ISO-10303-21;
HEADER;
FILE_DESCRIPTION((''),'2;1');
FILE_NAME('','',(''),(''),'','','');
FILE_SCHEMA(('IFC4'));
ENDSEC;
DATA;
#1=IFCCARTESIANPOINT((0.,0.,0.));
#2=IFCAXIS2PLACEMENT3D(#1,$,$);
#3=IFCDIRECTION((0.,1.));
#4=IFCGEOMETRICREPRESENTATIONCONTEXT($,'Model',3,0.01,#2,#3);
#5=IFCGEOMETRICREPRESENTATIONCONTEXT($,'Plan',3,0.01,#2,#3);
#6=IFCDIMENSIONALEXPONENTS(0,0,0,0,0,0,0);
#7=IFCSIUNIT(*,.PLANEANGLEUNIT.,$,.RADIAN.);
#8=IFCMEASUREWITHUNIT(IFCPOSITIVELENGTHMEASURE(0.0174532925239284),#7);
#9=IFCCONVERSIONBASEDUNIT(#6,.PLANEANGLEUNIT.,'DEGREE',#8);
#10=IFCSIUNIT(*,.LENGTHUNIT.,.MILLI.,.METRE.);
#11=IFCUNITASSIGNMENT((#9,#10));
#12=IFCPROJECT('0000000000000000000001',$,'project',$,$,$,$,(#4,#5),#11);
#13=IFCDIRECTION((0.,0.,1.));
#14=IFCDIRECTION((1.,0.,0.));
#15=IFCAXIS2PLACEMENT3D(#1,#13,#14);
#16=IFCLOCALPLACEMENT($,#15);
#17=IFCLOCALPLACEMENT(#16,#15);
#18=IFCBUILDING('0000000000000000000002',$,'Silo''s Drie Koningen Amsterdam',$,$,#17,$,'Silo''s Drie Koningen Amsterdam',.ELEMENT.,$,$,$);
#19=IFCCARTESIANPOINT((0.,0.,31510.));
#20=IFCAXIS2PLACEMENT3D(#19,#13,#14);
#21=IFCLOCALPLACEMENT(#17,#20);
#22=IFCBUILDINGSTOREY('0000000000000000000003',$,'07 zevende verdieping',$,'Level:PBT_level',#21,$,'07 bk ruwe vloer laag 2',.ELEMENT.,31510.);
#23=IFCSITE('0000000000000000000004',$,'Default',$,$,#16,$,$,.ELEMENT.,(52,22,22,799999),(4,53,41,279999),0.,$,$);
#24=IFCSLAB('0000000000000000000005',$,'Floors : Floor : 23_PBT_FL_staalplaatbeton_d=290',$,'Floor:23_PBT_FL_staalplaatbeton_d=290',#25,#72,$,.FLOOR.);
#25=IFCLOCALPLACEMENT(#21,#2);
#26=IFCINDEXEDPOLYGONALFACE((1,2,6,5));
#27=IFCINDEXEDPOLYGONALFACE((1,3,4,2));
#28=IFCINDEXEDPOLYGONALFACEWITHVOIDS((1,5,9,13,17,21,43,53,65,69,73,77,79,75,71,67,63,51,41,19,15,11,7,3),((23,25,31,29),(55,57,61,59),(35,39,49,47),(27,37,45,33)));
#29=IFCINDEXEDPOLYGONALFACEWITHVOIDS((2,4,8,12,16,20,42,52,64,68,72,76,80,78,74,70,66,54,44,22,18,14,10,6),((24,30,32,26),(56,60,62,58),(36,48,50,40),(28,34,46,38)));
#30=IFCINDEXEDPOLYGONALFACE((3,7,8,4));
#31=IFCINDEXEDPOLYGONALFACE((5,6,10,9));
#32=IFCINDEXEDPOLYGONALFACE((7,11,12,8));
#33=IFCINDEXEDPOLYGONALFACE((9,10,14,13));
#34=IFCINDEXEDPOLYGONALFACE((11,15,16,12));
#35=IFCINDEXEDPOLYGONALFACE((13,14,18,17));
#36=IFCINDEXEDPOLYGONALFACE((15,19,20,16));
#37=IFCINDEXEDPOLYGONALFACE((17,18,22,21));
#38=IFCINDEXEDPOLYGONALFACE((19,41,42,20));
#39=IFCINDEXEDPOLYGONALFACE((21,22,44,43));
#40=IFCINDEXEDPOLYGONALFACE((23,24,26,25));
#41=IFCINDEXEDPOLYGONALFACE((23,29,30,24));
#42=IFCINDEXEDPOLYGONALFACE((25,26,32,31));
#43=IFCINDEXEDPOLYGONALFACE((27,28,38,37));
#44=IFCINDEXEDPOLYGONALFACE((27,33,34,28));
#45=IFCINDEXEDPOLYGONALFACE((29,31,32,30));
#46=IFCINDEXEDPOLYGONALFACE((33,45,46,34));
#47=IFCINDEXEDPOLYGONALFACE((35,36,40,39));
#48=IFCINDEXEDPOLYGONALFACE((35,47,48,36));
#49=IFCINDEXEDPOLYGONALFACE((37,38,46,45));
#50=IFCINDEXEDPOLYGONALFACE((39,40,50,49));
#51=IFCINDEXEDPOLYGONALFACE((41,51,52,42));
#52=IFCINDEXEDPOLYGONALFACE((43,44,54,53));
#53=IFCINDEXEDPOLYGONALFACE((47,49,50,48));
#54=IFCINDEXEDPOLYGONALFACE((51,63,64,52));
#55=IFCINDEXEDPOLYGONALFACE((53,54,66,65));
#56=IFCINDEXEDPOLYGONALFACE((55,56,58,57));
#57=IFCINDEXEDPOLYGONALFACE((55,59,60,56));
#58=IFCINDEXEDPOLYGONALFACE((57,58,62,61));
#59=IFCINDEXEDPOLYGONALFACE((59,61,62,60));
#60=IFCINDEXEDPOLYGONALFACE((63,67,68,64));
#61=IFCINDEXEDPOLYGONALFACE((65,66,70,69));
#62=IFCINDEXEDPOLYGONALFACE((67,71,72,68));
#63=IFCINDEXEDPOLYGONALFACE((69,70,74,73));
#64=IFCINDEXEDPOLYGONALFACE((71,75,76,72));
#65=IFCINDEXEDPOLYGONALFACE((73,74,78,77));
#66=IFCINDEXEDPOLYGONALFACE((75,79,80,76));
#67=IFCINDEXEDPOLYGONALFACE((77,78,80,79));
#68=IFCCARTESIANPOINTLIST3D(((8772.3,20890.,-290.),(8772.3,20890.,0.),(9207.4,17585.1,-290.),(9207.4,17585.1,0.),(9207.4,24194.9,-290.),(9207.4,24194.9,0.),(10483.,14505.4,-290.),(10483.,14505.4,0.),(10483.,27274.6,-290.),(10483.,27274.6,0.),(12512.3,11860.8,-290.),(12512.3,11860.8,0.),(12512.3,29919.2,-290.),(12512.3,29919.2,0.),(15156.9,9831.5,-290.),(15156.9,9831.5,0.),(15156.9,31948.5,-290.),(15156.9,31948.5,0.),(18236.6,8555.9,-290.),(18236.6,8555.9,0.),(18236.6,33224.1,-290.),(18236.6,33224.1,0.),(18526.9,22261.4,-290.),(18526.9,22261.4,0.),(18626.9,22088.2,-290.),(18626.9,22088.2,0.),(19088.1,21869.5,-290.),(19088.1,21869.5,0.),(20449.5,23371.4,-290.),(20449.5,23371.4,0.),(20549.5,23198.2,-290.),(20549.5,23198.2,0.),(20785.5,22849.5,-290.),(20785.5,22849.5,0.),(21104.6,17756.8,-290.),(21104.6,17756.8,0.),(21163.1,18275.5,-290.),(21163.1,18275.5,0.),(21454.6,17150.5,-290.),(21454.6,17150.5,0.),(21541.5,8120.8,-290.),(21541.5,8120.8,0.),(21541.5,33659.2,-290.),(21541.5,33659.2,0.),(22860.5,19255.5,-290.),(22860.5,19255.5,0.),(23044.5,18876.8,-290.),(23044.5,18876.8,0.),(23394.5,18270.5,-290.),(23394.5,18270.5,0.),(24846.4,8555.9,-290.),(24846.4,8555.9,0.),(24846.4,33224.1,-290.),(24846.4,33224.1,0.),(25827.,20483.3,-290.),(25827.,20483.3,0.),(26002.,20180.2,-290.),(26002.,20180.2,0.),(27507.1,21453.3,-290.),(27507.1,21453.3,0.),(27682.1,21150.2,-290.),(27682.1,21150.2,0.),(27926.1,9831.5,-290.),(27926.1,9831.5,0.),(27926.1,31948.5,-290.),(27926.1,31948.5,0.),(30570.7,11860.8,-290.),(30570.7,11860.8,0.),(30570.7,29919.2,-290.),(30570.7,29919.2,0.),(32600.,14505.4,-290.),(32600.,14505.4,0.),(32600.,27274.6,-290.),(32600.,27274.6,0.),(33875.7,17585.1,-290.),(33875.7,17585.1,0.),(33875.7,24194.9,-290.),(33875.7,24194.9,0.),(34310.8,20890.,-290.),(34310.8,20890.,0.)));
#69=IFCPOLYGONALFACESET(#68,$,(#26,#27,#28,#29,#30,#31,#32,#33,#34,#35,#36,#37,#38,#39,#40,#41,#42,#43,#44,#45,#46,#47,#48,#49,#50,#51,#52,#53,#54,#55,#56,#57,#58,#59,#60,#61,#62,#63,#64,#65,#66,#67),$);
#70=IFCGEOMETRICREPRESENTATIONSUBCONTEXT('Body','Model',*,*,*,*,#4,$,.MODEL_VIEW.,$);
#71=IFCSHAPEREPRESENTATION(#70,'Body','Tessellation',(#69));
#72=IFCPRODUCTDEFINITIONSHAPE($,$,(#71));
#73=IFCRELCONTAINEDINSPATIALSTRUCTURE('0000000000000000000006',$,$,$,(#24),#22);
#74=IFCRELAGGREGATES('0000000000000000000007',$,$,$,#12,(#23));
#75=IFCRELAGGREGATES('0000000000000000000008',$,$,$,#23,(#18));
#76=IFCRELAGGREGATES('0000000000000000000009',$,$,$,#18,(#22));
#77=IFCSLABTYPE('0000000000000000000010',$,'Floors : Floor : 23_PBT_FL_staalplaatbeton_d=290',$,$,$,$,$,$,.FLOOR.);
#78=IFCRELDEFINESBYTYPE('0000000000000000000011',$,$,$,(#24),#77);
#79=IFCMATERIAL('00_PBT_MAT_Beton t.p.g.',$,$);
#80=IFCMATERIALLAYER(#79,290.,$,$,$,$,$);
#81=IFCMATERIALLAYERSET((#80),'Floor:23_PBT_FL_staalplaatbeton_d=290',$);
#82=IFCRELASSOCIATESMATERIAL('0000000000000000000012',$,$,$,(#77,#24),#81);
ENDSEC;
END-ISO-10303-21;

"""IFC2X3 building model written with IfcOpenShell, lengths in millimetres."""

from ifc_helpers import new_model, entity, si_unit, converted_unit, direction, frame, frame_2d, origin, origin_with_axes, place, context, subcontext, project, spatial, polyline, rectangle, outline, extrude, material, layer, layer_set, layer_usage, type_object, element, save


model = new_model("IFC2X3")

# Units and contexts
model_context = context("Model", 3, precision=0.01, world=origin(), true_north=direction((0.0, 1.0)))
plan_context = context("Plan", 3, precision=0.01, world=origin(), true_north=direction((0.0, 1.0)))
body_context = subcontext(model_context, "Body", "Model", "MODEL_VIEW")
ifc_project = project(units=[converted_unit("PLANEANGLEUNIT", "DEGREE", entity("IfcPositiveLengthMeasure", 0.0174532925239284), si_unit("PLANEANGLEUNIT", "RADIAN"), dimensions=[0, 0, 0, 0, 0, 0, 0]), si_unit("LENGTHUNIT", "METRE", prefix="MILLI")], contexts=[model_context, plan_context])

# Site, building, storey
site_placement = place(None, origin_with_axes())
site = spatial("IfcSite", under=ifc_project, at=site_placement, Name="Default", CompositionType="ELEMENT", RefLatitude=(52, 22, 22, 799999), RefLongitude=(4, 53, 41, 279999), RefElevation=0.0)
building_placement = place(site_placement, origin_with_axes())
building = spatial("IfcBuilding", under=site, at=building_placement, Name="Silo's Drie Koningen Amsterdam", LongName="Silo's Drie Koningen Amsterdam", CompositionType="ELEMENT")
storey_placement = place(building_placement, frame((0.0, 0.0, 31510.0), z_axis=(0.0, 0.0, 1.0), x_axis=(1.0, 0.0, 0.0)))
storey = spatial("IfcBuildingStorey", under=building, at=storey_placement, Name="07 zevende verdieping", ObjectType="Level:PBT_level", LongName="07 bk ruwe vloer laag 2", CompositionType="ELEMENT", Elevation=31510.0)

# Slab, openings
ifc_material = material(Name="00_PBT_MAT_Beton t.p.g.")
ifc_layer = layer(ifc_material, 290.0)
ifc_layer_set = layer_set([ifc_layer], Name="Floor:23_PBT_FL_staalplaatbeton_d=290")
ifc_layer_usage = layer_usage(ifc_layer_set, "AXIS3", "POSITIVE", 0.0)
slab_type = type_object("IfcSlabType", Name="Floors : Floor : 23_PBT_FL_staalplaatbeton_d=290", PredefinedType="FLOOR", material=ifc_layer_set)
slab_placement = place(storey_placement, frame((8772.3, 8120.8, -290.0), z_axis=(0.0, 0.0, 1.0), x_axis=(1.0, 0.0, 0.0)))
slab = element("IfcSlab", 1, at=slab_placement, inside=storey, type_object=slab_type, material=ifc_layer_usage, Name="Floors : Floor : 23_PBT_FL_staalplaatbeton_d=290", ObjectType="Floor:23_PBT_FL_staalplaatbeton_d=290", PredefinedType="FLOOR", context=body_context, shape_type="SweptSolid", body=[
    extrude(outline(polyline([(9029.2, -9029.2), (11058.5, -6384.6), (12334.1, -3304.9), (12769.2, 0.0), (12334.1, 3304.9), (11058.5, 6384.6), (9029.2, 9029.2), (6384.6, 11058.5), (3304.9, 12334.1), (0.0, 12769.2), (-3304.9, 12334.1), (-6384.6, 11058.5), (-9029.2, 9029.2), (-11058.5, 6384.6), (-12334.1, 3304.9), (-12769.2, 0.0), (-12334.1, -3304.9), (-11058.5, -6384.6), (-9029.2, -9029.2), (-6384.6, -11058.5), (-3304.9, -12334.1), (0.0, -12769.2), (3304.9, -12334.1), (6384.6, -11058.5), (9029.2, -9029.2)])), frame((12769.2, 12769.2, 290.0), z_axis=(0.0, 0.0, -1.0), x_axis=(-1.0, 0.0, 0.0)), (0.0, 0.0, 1.0), 290.0),
])
opening_1_placement = place(slab_placement, origin_with_axes())
element("IfcOpeningElement", 2, at=opening_1_placement, cuts=slab, ObjectType="Opening", context=body_context, shape_type="SweptSolid", body=[
    extrude(outline(polyline([(-980.0, -2075.0), (980.0, -2075.0), (980.0, 2075.0), (-980.0, 2075.0), (-980.0, -2075.0)])), frame((12202.0, 12441.7, 0.0), z_axis=(0.0, 0.0, 1.0), x_axis=(-0.866025, -0.5, 0.0)), (0.0, 0.0, 1.0), 290.0),
])
opening_2_placement = place(slab_placement, origin_with_axes())
element("IfcOpeningElement", 3, at=opening_2_placement, cuts=slab, ObjectType="Opening", context=body_context, shape_type="SweptSolid", body=[
    extrude(rectangle(XDim=700.0, YDim=2240.0, at=frame_2d((0.0, 0.0), x_axis=(1.0, 0.0))), frame((13477.3, 9892.9, 0.0), z_axis=(0.0, 0.0, 1.0), x_axis=(0.5, -0.866025, 0.0)), (0.0, 0.0, 1.0), 290.0),
])
opening_3_placement = place(slab_placement, origin_with_axes())
element("IfcOpeningElement", 4, at=opening_3_placement, cuts=slab, ObjectType="Opening", context=body_context, shape_type="SweptSolid", body=[
    extrude(rectangle(XDim=1940.0, YDim=350.0, at=frame_2d((0.0, 0.0), x_axis=(1.0, 0.0))), frame((17982.3, 12696.0, 0.0), z_axis=(0.0, 0.0, 1.0), x_axis=(-0.866025, -0.5, 0.0)), (0.0, 0.0, 1.0), 290.0),
])
opening_4_placement = place(slab_placement, origin_with_axes())
element("IfcOpeningElement", 5, at=opening_4_placement, cuts=slab, ObjectType="Opening", context=body_context, shape_type="SweptSolid", body=[
    extrude(rectangle(XDim=200.0, YDim=2220.0, at=frame_2d((0.0, 0.0), x_axis=(1.0, 0.0))), frame((10765.9, 14609.1, 0.0), z_axis=(0.0, 0.0, 1.0), x_axis=(0.5, -0.866025, 0.0)), (0.0, 0.0, 1.0), 290.0),
])

save(model, "model.ifc")
